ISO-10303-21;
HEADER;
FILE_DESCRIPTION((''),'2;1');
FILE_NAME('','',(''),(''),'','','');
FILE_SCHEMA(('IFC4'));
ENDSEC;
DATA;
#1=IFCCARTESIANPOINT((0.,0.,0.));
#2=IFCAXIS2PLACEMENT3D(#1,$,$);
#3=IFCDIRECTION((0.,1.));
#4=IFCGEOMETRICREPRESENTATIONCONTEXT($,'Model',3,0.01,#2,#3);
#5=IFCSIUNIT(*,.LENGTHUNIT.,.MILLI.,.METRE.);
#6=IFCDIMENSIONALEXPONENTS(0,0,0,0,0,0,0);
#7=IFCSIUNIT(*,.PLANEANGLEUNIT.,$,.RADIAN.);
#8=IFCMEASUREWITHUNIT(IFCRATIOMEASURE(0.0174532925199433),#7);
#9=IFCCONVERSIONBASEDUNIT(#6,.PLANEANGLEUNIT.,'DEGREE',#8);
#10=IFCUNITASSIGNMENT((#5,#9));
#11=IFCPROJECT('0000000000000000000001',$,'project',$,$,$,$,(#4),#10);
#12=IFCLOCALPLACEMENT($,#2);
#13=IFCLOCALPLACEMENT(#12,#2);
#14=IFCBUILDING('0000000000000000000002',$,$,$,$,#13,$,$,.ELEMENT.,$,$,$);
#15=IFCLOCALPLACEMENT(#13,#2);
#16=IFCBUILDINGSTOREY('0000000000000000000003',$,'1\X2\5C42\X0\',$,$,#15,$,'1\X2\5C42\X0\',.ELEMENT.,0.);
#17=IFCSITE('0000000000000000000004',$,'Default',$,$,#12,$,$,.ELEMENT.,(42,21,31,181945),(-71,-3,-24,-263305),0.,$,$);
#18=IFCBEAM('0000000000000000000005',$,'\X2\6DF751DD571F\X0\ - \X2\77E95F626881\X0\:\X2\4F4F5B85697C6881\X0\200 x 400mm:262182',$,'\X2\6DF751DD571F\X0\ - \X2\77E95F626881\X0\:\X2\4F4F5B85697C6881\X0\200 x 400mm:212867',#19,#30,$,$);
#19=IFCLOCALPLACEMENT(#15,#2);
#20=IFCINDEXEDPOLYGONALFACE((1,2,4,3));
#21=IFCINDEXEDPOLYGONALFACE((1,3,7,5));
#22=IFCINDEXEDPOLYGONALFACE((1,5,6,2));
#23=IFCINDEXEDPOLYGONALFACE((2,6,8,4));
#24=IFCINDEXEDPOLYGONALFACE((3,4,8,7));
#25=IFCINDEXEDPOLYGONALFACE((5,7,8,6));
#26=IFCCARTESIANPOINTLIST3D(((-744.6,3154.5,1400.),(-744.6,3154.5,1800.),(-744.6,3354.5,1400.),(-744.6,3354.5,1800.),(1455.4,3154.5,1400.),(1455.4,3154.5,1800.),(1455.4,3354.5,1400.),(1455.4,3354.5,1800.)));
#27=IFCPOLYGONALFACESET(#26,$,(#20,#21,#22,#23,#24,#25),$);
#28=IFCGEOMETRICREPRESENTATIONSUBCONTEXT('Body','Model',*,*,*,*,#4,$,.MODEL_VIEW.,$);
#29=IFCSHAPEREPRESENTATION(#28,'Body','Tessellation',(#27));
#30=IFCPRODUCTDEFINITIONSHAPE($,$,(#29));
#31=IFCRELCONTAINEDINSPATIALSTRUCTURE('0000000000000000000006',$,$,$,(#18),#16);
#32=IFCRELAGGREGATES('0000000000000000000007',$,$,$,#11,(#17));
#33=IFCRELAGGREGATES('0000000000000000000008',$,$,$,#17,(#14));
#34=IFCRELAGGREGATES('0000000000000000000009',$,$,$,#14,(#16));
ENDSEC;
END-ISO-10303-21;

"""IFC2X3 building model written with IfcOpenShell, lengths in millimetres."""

from ifc_helpers import new_model, entity, si_unit, converted_unit, direction, frame, frame_2d, origin, place, context, subcontext, project, spatial, rectangle, extrude, element, save


model = new_model("IFC2X3")

# Units and contexts
model_context = context("Model", 3, precision=0.01, world=origin(), true_north=direction((0.0, 1.0)))
body_context = subcontext(model_context, "Body", "Model", "MODEL_VIEW")
ifc_project = project(units=[si_unit("LENGTHUNIT", "METRE", prefix="MILLI"), converted_unit("PLANEANGLEUNIT", "DEGREE", entity("IfcRatioMeasure", 0.0174532925199433), si_unit("PLANEANGLEUNIT", "RADIAN"), dimensions=[0, 0, 0, 0, 0, 0, 0])], contexts=[model_context])

# Site, building, storey
site_placement = place(None, origin())
site = spatial("IfcSite", under=ifc_project, at=site_placement, Name="Default", CompositionType="ELEMENT", RefLatitude=(42, 21, 31, 181945), RefLongitude=(-71, -3, -24, -263305), RefElevation=0.0)
building_placement = place(site_placement, origin())
building = spatial("IfcBuilding", under=site, at=building_placement, CompositionType="ELEMENT")
storey_placement = place(building_placement, origin())
storey = spatial("IfcBuildingStorey", under=building, at=storey_placement, Name="1层", LongName="1层", CompositionType="ELEMENT", Elevation=0.0)

# Beam
beam_1_placement = place(storey_placement, frame((-944.6, 3254.5, 0.0)))
element("IfcBeam", 1, at=beam_1_placement, inside=storey, Name="混凝土 - 矩形梁:住宅楼梁200 x 400mm:262182", ObjectType="混凝土 - 矩形梁:住宅楼梁200 x 400mm:212867", context=body_context, shape_type="SweptSolid", body=[
    extrude(rectangle(XDim=400.0, YDim=200.0, at=frame_2d((0.0, 0.0), x_axis=(1.0, 0.0))), frame((200.0, 0.0, 1600.0), z_axis=(1.0, 0.0, 0.0), x_axis=(0.0, 0.0, -1.0)), (0.0, 0.0, 1.0), 2200.0),
])

save(model, "model.ifc")
